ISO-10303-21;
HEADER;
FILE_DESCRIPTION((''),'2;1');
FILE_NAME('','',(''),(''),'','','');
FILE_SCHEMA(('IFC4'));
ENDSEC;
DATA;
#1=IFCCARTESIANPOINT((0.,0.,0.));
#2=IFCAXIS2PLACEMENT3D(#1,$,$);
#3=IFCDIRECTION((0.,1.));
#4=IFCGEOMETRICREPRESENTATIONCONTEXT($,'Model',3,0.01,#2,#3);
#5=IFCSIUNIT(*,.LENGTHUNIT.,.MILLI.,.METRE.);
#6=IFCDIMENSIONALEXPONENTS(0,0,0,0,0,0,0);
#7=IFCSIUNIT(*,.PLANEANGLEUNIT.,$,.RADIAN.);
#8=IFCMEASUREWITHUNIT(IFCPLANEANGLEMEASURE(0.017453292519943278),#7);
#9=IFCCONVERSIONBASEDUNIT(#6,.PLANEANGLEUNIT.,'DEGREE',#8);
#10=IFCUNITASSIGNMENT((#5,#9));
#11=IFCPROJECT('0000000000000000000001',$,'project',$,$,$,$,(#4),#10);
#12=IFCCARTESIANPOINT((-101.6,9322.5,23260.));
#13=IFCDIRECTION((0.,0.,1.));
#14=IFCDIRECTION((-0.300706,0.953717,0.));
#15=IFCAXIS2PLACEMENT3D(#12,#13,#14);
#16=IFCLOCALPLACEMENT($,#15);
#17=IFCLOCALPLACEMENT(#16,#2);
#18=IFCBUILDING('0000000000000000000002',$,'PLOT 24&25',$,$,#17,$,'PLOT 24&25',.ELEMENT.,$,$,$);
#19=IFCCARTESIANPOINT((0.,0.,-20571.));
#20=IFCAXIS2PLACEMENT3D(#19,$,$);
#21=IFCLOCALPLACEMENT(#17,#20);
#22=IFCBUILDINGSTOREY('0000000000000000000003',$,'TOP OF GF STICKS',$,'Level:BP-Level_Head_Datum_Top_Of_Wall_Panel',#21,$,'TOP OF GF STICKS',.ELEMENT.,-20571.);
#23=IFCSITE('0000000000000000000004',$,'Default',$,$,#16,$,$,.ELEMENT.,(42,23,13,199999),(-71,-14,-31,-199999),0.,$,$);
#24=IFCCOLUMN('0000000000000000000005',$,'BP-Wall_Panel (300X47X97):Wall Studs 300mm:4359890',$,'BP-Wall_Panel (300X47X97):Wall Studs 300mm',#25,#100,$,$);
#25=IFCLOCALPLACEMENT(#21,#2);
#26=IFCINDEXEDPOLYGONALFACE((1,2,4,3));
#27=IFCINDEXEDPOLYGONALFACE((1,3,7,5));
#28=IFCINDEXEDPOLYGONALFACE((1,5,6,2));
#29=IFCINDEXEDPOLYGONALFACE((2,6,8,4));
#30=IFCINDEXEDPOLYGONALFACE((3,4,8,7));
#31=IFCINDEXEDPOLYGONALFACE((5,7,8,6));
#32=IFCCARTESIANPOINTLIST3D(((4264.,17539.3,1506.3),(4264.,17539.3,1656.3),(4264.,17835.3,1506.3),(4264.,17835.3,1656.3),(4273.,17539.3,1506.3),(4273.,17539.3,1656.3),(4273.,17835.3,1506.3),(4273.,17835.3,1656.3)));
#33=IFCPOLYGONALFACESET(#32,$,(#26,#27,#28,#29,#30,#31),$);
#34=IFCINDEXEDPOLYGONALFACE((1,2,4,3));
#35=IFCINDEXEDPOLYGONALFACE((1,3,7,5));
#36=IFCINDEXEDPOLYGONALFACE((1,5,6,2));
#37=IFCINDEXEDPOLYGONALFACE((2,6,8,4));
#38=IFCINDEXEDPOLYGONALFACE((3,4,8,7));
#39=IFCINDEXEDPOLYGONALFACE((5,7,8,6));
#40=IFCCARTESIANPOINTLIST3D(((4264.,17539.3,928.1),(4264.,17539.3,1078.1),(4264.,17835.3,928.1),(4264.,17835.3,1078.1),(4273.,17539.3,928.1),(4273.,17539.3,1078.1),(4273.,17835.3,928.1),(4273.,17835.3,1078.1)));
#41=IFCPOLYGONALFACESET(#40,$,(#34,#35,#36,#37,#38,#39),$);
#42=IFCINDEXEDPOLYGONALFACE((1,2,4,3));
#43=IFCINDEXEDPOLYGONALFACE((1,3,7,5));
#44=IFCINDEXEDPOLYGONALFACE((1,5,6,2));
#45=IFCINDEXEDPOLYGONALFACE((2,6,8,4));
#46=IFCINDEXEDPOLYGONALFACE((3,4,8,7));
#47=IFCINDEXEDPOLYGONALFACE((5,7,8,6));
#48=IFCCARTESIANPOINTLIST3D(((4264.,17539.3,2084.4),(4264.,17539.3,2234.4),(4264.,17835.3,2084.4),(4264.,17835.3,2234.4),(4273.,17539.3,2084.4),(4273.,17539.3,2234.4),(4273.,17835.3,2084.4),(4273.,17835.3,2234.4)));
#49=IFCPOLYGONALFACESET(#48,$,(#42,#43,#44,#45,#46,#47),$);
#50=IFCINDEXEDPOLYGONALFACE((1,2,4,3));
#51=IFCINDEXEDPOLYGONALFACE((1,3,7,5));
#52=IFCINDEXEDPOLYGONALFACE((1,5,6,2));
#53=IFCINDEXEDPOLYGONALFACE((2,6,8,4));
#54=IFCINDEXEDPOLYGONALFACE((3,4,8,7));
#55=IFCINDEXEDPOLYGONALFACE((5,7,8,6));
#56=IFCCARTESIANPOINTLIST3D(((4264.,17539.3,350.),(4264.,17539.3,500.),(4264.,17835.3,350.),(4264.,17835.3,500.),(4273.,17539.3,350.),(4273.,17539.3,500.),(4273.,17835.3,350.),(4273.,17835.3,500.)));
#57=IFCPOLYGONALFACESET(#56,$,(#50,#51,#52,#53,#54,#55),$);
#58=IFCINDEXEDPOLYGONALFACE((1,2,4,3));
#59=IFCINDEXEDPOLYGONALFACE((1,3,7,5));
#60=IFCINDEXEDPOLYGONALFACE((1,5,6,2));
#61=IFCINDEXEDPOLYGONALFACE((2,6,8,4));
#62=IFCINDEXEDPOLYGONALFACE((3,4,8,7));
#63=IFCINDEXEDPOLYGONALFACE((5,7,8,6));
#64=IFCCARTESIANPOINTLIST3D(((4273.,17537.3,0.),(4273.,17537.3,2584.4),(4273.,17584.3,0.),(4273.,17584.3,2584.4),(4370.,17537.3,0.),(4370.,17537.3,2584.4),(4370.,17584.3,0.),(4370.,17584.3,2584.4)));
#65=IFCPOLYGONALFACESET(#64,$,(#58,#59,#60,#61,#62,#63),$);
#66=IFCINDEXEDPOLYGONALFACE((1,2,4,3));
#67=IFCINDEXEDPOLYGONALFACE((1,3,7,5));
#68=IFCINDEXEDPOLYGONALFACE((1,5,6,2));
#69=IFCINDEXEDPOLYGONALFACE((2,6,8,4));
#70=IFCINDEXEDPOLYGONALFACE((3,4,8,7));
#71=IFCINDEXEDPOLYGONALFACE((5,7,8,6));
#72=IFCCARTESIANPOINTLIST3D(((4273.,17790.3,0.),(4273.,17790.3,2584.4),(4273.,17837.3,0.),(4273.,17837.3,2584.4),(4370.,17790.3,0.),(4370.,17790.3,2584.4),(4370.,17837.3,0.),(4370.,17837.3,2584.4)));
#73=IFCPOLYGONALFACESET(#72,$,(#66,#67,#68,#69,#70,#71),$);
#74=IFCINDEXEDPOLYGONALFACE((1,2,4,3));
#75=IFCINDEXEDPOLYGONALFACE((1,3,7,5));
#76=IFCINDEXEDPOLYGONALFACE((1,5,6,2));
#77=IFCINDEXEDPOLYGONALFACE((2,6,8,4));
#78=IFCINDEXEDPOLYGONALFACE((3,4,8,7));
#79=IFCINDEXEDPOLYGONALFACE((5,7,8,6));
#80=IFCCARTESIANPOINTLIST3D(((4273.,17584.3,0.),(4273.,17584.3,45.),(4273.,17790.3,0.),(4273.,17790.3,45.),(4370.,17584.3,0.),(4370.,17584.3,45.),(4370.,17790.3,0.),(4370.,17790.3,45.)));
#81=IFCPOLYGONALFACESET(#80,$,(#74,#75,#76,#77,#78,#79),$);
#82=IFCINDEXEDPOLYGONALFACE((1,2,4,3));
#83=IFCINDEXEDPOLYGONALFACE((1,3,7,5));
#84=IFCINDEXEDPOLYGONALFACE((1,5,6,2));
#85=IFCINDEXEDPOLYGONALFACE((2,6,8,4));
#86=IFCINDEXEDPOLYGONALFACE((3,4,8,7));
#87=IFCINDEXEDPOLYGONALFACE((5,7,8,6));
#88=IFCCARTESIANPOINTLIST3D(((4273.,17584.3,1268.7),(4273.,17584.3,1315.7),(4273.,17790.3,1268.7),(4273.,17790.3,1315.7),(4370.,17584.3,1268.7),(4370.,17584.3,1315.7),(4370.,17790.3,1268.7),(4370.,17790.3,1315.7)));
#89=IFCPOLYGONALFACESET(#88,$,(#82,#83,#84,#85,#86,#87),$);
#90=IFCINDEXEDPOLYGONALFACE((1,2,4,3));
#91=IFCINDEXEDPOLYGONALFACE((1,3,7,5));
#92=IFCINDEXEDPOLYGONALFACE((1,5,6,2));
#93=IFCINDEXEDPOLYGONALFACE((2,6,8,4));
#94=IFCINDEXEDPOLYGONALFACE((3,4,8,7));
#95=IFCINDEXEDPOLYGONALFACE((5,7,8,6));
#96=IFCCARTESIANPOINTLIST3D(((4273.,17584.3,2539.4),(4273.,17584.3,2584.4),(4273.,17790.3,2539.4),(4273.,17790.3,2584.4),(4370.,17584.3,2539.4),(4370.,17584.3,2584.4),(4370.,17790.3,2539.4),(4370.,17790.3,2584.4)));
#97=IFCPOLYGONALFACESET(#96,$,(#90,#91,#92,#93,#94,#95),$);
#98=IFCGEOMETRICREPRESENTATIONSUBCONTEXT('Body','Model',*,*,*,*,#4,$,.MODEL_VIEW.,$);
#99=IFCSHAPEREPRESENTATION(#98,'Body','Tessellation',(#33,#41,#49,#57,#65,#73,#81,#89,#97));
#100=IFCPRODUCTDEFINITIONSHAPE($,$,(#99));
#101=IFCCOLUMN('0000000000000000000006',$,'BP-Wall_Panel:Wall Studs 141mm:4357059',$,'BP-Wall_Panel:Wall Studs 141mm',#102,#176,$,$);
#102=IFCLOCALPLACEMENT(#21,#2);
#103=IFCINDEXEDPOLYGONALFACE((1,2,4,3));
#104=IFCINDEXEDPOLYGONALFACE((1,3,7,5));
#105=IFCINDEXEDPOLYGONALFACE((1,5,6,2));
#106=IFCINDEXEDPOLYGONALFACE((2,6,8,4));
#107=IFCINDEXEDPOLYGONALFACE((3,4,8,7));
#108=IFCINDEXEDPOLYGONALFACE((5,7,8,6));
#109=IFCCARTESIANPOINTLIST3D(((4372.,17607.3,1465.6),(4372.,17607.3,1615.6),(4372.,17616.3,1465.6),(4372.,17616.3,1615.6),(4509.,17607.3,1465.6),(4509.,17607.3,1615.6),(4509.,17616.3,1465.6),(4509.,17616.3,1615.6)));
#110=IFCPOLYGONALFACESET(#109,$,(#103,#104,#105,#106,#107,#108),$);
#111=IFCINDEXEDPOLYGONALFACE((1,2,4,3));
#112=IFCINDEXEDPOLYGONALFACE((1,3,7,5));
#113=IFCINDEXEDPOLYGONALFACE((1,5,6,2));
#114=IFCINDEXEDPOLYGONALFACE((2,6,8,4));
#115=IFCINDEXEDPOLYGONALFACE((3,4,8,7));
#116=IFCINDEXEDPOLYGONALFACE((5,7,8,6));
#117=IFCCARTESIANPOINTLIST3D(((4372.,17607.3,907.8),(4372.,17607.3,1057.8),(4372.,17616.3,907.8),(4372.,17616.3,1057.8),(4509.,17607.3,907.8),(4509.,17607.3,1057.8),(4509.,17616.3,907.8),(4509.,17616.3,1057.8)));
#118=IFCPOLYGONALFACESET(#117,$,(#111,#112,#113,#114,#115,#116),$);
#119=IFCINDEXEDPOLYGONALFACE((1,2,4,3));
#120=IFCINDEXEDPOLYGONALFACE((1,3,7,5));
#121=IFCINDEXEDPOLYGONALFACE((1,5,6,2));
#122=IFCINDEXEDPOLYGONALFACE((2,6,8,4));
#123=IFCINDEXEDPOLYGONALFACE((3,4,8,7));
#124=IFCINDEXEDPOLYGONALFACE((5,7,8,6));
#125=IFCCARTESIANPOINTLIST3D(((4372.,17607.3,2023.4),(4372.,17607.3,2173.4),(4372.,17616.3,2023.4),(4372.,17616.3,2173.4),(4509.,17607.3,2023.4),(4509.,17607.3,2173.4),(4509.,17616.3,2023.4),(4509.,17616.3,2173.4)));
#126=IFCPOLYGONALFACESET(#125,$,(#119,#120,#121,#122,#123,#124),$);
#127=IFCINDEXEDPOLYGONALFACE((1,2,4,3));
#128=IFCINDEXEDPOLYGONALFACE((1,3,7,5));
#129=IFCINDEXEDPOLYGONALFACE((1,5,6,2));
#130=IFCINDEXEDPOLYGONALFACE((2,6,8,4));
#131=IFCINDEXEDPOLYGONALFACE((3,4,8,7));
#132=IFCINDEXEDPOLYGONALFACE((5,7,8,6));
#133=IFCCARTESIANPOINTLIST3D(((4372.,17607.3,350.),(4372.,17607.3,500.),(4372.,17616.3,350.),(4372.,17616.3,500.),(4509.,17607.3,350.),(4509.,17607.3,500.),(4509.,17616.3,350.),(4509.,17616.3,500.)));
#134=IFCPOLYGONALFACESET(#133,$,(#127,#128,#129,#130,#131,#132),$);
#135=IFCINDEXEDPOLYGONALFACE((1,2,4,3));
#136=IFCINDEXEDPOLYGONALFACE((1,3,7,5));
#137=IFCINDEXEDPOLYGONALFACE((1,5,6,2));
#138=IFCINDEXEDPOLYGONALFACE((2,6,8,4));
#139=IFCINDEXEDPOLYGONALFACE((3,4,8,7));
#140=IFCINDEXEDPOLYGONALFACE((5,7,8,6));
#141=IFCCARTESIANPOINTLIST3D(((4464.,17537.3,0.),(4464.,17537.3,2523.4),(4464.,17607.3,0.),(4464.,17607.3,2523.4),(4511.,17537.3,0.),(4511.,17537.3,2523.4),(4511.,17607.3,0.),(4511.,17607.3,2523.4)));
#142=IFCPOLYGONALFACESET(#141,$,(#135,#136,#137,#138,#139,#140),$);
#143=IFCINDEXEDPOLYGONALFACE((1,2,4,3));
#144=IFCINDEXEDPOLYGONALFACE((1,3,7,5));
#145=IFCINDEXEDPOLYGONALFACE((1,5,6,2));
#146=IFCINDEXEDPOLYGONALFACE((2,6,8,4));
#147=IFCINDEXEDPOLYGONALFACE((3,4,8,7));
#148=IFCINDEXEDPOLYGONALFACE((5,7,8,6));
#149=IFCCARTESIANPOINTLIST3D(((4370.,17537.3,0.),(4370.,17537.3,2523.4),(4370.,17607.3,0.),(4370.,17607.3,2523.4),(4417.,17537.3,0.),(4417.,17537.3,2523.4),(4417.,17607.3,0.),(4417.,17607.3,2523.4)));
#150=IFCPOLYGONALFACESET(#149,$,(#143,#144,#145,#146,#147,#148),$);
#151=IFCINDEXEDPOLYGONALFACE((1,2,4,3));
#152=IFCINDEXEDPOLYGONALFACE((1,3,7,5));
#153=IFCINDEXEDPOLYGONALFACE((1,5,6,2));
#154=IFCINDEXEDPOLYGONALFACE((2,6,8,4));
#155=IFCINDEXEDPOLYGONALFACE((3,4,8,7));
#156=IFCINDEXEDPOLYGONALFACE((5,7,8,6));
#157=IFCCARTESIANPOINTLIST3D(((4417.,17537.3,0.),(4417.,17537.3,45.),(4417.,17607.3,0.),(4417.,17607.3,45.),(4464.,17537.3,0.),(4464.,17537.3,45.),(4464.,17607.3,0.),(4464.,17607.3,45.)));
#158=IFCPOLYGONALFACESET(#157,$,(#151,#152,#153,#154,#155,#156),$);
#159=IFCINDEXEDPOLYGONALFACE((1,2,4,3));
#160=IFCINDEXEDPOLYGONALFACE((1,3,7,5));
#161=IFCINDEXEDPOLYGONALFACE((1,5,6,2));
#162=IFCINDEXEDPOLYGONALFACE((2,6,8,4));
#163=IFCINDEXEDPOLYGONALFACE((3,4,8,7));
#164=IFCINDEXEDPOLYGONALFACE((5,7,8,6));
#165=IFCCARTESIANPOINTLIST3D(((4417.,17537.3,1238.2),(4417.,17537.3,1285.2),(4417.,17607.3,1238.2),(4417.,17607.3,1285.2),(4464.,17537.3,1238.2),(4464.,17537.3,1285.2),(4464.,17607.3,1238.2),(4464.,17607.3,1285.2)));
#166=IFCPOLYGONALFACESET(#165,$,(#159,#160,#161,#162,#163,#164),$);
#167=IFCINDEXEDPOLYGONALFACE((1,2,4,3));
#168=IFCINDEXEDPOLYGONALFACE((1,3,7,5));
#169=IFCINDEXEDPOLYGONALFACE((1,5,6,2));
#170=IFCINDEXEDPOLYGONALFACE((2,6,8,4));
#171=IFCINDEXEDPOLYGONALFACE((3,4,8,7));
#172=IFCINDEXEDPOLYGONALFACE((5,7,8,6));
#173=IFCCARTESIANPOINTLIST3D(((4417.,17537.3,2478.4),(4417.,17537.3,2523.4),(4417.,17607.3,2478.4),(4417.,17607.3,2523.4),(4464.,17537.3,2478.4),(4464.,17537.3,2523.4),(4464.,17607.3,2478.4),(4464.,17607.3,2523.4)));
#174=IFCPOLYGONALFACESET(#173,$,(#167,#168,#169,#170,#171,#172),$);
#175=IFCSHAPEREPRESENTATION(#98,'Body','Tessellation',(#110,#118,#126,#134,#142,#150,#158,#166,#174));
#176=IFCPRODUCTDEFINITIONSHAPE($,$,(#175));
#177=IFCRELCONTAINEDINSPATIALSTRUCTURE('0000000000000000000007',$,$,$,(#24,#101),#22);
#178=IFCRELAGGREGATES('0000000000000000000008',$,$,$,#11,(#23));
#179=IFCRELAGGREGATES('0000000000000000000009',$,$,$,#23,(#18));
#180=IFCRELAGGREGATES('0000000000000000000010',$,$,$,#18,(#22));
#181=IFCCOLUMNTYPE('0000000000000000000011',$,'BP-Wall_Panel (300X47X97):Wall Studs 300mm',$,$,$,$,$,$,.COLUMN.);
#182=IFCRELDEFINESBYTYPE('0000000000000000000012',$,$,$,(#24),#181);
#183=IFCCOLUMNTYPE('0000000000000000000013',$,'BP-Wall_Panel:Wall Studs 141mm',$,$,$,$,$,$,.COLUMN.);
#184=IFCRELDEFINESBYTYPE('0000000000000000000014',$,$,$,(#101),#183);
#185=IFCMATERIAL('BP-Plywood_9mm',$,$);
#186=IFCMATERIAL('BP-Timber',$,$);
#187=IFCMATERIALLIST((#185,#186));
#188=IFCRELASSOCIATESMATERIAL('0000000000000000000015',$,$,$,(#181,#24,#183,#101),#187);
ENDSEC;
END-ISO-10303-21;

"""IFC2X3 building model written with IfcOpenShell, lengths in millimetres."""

from ifc_helpers import new_model, entity, si_unit, converted_unit, direction, frame, frame_2d, origin, origin_2d_with_axis, place, context, subcontext, project, spatial, rectangle, extrude, source, transform, mapped, material, material_list, type_object, type_shapes, element, save


model = new_model("IFC2X3")

# Units and contexts
model_context = context("Model", 3, precision=0.01, world=origin(), true_north=direction((0.0, 1.0)))
body_context = subcontext(model_context, "Body", "Model", "MODEL_VIEW")
ifc_project = project(units=[si_unit("LENGTHUNIT", "METRE", prefix="MILLI"), converted_unit("PLANEANGLEUNIT", "DEGREE", entity("IfcPlaneAngleMeasure", 0.017453292519943278), si_unit("PLANEANGLEUNIT", "RADIAN"), dimensions=[0, 0, 0, 0, 0, 0, 0])], contexts=[model_context])

# Site, building, storey
site_placement = place(None, frame((-101.6, 9322.5, 23260.0), z_axis=(0.0, 0.0, 1.0), x_axis=(-0.300706, 0.953717, 0.0)))
site = spatial("IfcSite", under=ifc_project, at=site_placement, Name="Default", CompositionType="ELEMENT", RefLatitude=(42, 23, 13, 199999), RefLongitude=(-71, -14, -31, -199999), RefElevation=0.0)
building_placement = place(site_placement, origin())
building = spatial("IfcBuilding", under=site, at=building_placement, Name="PLOT 24&25", LongName="PLOT 24&25", CompositionType="ELEMENT")
storey_placement = place(building_placement, frame((0.0, 0.0, -20571.0)))
storey = spatial("IfcBuildingStorey", under=building, at=storey_placement, Name="TOP OF GF STICKS", ObjectType="Level:BP-Level_Head_Datum_Top_Of_Wall_Panel", LongName="TOP OF GF STICKS", CompositionType="ELEMENT", Elevation=-20571.0)

# Columns
ifc_material_1 = material(Name="BP-Plywood_9mm")
ifc_material_2 = material(Name="BP-Timber")
ifc_material_list = material_list([ifc_material_1, ifc_material_2])
column_type_1 = type_object("IfcColumnType", Name="BP-Wall_Panel (300X47X97):Wall Studs 300mm", PredefinedType="COLUMN", material=ifc_material_list)
shared_shape_1 = source(origin(), body_context, "Body", "SweptSolid", [
    extrude(rectangle(XDim=9.0, YDim=296.0, at=origin_2d_with_axis()), frame((-53.0, 0.0, -19064.7), z_axis=(0.0, 0.0, 1.0), x_axis=(-1.0, 0.0, 0.0)), (0.0, 0.0, 1.0), 150.0),
    extrude(rectangle(XDim=9.0, YDim=296.0, at=origin_2d_with_axis()), frame((-53.0, 0.0, -19642.9), z_axis=(0.0, 0.0, 1.0), x_axis=(-1.0, 0.0, 0.0)), (0.0, 0.0, 1.0), 150.0),
    extrude(rectangle(XDim=9.0, YDim=296.0, at=origin_2d_with_axis()), frame((-53.0, 0.0, -18486.6), z_axis=(0.0, 0.0, 1.0), x_axis=(-1.0, 0.0, 0.0)), (0.0, 0.0, 1.0), 150.0),
    extrude(rectangle(XDim=9.0, YDim=296.0, at=origin_2d_with_axis()), frame((-53.0, 0.0, -20221.0), z_axis=(0.0, 0.0, 1.0), x_axis=(-1.0, 0.0, 0.0)), (0.0, 0.0, 1.0), 150.0),
    extrude(rectangle(XDim=97.0, YDim=47.0, at=origin_2d_with_axis()), frame((0.0, -126.5, -20571.0), z_axis=(0.0, 0.0, 1.0), x_axis=(-1.0, 0.0, 0.0)), (0.0, 0.0, 1.0), 2584.4),
    extrude(rectangle(XDim=97.0, YDim=47.0, at=frame_2d((0.0, 0.0), x_axis=(1.0, 0.0))), frame((0.0, 126.5, -20571.0), z_axis=(0.0, 0.0, 1.0), x_axis=(-1.0, 0.0, 0.0)), (0.0, 0.0, 1.0), 2584.4),
    extrude(rectangle(XDim=206.0, YDim=97.0, at=origin_2d_with_axis()), frame((0.0, 0.0, -20571.0), z_axis=(0.0, 0.0, 1.0), x_axis=(0.0, -1.0, 0.0)), (0.0, 0.0, 1.0), 45.0),
    extrude(rectangle(XDim=206.0, YDim=97.0, at=origin_2d_with_axis()), frame((0.0, 0.0, -19302.3), z_axis=(0.0, 0.0, 1.0), x_axis=(0.0, -1.0, 0.0)), (0.0, 0.0, 1.0), 47.0),
    extrude(rectangle(XDim=206.0, YDim=97.0, at=origin_2d_with_axis()), frame((0.0, 0.0, -18031.6), z_axis=(0.0, 0.0, 1.0), x_axis=(0.0, -1.0, 0.0)), (0.0, 0.0, 1.0), 45.0),
])
type_shapes(column_type_1, [shared_shape_1])
column_1_placement = place(storey_placement, frame((4321.5, 17687.3, 20571.0)))
element("IfcColumn", 1, at=column_1_placement, inside=storey, type_object=column_type_1, material=ifc_material_list, Name="BP-Wall_Panel (300X47X97):Wall Studs 300mm:4359890", ObjectType="BP-Wall_Panel (300X47X97):Wall Studs 300mm", context=body_context, shape_type="MappedRepresentation", body=[
    mapped(shared_shape_1, transform((0.0, 0.0, 0.0), scale=1.0)),
])
column_type_2 = type_object("IfcColumnType", Name="BP-Wall_Panel:Wall Studs 141mm", PredefinedType="COLUMN", material=ifc_material_list)
shared_shape_2 = source(origin(), body_context, "Body", "SweptSolid", [
    extrude(rectangle(XDim=137.0, YDim=9.0, at=origin_2d_with_axis()), frame((39.5, 0.0, -19105.4), z_axis=(0.0, 0.0, 1.0), x_axis=(0.0, -1.0, 0.0)), (0.0, 0.0, 1.0), 150.0),
    extrude(rectangle(XDim=137.0, YDim=9.0, at=origin_2d_with_axis()), frame((39.5, 0.0, -19663.2), z_axis=(0.0, 0.0, 1.0), x_axis=(0.0, -1.0, 0.0)), (0.0, 0.0, 1.0), 150.0),
    extrude(rectangle(XDim=137.0, YDim=9.0, at=frame_2d((0.0, 0.0), x_axis=(1.0, 0.0))), frame((39.5, 0.0, -18547.6), z_axis=(0.0, 0.0, 1.0), x_axis=(0.0, -1.0, 0.0)), (0.0, 0.0, 1.0), 150.0),
    extrude(rectangle(XDim=137.0, YDim=9.0, at=origin_2d_with_axis()), frame((39.5, 0.0, -20221.0), z_axis=(0.0, 0.0, 1.0), x_axis=(0.0, -1.0, 0.0)), (0.0, 0.0, 1.0), 150.0),
    extrude(rectangle(XDim=70.0, YDim=47.0, at=origin_2d_with_axis()), frame((0.0, -47.0, -20571.0), z_axis=(0.0, 0.0, 1.0), x_axis=(-1.0, 0.0, 0.0)), (0.0, 0.0, 1.0), 2523.4),
    extrude(rectangle(XDim=70.0, YDim=47.0, at=origin_2d_with_axis()), frame((0.0, 47.0, -20571.0), z_axis=(0.0, 0.0, 1.0), x_axis=(-1.0, 0.0, 0.0)), (0.0, 0.0, 1.0), 2523.4),
    extrude(rectangle(XDim=47.0, YDim=70.0, at=origin_2d_with_axis()), frame((0.0, 0.0, -20571.0), z_axis=(0.0, 0.0, 1.0), x_axis=(0.0, -1.0, 0.0)), (0.0, 0.0, 1.0), 45.0),
    extrude(rectangle(XDim=47.0, YDim=70.0, at=origin_2d_with_axis()), frame((0.0, 0.0, -19332.8), z_axis=(0.0, 0.0, 1.0), x_axis=(0.0, -1.0, 0.0)), (0.0, 0.0, 1.0), 47.0),
    extrude(rectangle(XDim=47.0, YDim=70.0, at=origin_2d_with_axis()), frame((0.0, 0.0, -18092.6), z_axis=(0.0, 0.0, 1.0), x_axis=(0.0, -1.0, 0.0)), (0.0, 0.0, 1.0), 45.0),
])
type_shapes(column_type_2, [shared_shape_2])
column_2_placement = place(storey_placement, frame((4440.5, 17572.3, 20571.0), z_axis=(0.0, 0.0, 1.0), x_axis=(0.0, 1.0, 0.0)))
element("IfcColumn", 2, at=column_2_placement, inside=storey, type_object=column_type_2, material=ifc_material_list, Name="BP-Wall_Panel:Wall Studs 141mm:4357059", ObjectType="BP-Wall_Panel:Wall Studs 141mm", context=body_context, shape_type="MappedRepresentation", body=[
    mapped(shared_shape_2, transform((0.0, 0.0, 0.0), scale=1.0)),
])

save(model, "model.ifc")
